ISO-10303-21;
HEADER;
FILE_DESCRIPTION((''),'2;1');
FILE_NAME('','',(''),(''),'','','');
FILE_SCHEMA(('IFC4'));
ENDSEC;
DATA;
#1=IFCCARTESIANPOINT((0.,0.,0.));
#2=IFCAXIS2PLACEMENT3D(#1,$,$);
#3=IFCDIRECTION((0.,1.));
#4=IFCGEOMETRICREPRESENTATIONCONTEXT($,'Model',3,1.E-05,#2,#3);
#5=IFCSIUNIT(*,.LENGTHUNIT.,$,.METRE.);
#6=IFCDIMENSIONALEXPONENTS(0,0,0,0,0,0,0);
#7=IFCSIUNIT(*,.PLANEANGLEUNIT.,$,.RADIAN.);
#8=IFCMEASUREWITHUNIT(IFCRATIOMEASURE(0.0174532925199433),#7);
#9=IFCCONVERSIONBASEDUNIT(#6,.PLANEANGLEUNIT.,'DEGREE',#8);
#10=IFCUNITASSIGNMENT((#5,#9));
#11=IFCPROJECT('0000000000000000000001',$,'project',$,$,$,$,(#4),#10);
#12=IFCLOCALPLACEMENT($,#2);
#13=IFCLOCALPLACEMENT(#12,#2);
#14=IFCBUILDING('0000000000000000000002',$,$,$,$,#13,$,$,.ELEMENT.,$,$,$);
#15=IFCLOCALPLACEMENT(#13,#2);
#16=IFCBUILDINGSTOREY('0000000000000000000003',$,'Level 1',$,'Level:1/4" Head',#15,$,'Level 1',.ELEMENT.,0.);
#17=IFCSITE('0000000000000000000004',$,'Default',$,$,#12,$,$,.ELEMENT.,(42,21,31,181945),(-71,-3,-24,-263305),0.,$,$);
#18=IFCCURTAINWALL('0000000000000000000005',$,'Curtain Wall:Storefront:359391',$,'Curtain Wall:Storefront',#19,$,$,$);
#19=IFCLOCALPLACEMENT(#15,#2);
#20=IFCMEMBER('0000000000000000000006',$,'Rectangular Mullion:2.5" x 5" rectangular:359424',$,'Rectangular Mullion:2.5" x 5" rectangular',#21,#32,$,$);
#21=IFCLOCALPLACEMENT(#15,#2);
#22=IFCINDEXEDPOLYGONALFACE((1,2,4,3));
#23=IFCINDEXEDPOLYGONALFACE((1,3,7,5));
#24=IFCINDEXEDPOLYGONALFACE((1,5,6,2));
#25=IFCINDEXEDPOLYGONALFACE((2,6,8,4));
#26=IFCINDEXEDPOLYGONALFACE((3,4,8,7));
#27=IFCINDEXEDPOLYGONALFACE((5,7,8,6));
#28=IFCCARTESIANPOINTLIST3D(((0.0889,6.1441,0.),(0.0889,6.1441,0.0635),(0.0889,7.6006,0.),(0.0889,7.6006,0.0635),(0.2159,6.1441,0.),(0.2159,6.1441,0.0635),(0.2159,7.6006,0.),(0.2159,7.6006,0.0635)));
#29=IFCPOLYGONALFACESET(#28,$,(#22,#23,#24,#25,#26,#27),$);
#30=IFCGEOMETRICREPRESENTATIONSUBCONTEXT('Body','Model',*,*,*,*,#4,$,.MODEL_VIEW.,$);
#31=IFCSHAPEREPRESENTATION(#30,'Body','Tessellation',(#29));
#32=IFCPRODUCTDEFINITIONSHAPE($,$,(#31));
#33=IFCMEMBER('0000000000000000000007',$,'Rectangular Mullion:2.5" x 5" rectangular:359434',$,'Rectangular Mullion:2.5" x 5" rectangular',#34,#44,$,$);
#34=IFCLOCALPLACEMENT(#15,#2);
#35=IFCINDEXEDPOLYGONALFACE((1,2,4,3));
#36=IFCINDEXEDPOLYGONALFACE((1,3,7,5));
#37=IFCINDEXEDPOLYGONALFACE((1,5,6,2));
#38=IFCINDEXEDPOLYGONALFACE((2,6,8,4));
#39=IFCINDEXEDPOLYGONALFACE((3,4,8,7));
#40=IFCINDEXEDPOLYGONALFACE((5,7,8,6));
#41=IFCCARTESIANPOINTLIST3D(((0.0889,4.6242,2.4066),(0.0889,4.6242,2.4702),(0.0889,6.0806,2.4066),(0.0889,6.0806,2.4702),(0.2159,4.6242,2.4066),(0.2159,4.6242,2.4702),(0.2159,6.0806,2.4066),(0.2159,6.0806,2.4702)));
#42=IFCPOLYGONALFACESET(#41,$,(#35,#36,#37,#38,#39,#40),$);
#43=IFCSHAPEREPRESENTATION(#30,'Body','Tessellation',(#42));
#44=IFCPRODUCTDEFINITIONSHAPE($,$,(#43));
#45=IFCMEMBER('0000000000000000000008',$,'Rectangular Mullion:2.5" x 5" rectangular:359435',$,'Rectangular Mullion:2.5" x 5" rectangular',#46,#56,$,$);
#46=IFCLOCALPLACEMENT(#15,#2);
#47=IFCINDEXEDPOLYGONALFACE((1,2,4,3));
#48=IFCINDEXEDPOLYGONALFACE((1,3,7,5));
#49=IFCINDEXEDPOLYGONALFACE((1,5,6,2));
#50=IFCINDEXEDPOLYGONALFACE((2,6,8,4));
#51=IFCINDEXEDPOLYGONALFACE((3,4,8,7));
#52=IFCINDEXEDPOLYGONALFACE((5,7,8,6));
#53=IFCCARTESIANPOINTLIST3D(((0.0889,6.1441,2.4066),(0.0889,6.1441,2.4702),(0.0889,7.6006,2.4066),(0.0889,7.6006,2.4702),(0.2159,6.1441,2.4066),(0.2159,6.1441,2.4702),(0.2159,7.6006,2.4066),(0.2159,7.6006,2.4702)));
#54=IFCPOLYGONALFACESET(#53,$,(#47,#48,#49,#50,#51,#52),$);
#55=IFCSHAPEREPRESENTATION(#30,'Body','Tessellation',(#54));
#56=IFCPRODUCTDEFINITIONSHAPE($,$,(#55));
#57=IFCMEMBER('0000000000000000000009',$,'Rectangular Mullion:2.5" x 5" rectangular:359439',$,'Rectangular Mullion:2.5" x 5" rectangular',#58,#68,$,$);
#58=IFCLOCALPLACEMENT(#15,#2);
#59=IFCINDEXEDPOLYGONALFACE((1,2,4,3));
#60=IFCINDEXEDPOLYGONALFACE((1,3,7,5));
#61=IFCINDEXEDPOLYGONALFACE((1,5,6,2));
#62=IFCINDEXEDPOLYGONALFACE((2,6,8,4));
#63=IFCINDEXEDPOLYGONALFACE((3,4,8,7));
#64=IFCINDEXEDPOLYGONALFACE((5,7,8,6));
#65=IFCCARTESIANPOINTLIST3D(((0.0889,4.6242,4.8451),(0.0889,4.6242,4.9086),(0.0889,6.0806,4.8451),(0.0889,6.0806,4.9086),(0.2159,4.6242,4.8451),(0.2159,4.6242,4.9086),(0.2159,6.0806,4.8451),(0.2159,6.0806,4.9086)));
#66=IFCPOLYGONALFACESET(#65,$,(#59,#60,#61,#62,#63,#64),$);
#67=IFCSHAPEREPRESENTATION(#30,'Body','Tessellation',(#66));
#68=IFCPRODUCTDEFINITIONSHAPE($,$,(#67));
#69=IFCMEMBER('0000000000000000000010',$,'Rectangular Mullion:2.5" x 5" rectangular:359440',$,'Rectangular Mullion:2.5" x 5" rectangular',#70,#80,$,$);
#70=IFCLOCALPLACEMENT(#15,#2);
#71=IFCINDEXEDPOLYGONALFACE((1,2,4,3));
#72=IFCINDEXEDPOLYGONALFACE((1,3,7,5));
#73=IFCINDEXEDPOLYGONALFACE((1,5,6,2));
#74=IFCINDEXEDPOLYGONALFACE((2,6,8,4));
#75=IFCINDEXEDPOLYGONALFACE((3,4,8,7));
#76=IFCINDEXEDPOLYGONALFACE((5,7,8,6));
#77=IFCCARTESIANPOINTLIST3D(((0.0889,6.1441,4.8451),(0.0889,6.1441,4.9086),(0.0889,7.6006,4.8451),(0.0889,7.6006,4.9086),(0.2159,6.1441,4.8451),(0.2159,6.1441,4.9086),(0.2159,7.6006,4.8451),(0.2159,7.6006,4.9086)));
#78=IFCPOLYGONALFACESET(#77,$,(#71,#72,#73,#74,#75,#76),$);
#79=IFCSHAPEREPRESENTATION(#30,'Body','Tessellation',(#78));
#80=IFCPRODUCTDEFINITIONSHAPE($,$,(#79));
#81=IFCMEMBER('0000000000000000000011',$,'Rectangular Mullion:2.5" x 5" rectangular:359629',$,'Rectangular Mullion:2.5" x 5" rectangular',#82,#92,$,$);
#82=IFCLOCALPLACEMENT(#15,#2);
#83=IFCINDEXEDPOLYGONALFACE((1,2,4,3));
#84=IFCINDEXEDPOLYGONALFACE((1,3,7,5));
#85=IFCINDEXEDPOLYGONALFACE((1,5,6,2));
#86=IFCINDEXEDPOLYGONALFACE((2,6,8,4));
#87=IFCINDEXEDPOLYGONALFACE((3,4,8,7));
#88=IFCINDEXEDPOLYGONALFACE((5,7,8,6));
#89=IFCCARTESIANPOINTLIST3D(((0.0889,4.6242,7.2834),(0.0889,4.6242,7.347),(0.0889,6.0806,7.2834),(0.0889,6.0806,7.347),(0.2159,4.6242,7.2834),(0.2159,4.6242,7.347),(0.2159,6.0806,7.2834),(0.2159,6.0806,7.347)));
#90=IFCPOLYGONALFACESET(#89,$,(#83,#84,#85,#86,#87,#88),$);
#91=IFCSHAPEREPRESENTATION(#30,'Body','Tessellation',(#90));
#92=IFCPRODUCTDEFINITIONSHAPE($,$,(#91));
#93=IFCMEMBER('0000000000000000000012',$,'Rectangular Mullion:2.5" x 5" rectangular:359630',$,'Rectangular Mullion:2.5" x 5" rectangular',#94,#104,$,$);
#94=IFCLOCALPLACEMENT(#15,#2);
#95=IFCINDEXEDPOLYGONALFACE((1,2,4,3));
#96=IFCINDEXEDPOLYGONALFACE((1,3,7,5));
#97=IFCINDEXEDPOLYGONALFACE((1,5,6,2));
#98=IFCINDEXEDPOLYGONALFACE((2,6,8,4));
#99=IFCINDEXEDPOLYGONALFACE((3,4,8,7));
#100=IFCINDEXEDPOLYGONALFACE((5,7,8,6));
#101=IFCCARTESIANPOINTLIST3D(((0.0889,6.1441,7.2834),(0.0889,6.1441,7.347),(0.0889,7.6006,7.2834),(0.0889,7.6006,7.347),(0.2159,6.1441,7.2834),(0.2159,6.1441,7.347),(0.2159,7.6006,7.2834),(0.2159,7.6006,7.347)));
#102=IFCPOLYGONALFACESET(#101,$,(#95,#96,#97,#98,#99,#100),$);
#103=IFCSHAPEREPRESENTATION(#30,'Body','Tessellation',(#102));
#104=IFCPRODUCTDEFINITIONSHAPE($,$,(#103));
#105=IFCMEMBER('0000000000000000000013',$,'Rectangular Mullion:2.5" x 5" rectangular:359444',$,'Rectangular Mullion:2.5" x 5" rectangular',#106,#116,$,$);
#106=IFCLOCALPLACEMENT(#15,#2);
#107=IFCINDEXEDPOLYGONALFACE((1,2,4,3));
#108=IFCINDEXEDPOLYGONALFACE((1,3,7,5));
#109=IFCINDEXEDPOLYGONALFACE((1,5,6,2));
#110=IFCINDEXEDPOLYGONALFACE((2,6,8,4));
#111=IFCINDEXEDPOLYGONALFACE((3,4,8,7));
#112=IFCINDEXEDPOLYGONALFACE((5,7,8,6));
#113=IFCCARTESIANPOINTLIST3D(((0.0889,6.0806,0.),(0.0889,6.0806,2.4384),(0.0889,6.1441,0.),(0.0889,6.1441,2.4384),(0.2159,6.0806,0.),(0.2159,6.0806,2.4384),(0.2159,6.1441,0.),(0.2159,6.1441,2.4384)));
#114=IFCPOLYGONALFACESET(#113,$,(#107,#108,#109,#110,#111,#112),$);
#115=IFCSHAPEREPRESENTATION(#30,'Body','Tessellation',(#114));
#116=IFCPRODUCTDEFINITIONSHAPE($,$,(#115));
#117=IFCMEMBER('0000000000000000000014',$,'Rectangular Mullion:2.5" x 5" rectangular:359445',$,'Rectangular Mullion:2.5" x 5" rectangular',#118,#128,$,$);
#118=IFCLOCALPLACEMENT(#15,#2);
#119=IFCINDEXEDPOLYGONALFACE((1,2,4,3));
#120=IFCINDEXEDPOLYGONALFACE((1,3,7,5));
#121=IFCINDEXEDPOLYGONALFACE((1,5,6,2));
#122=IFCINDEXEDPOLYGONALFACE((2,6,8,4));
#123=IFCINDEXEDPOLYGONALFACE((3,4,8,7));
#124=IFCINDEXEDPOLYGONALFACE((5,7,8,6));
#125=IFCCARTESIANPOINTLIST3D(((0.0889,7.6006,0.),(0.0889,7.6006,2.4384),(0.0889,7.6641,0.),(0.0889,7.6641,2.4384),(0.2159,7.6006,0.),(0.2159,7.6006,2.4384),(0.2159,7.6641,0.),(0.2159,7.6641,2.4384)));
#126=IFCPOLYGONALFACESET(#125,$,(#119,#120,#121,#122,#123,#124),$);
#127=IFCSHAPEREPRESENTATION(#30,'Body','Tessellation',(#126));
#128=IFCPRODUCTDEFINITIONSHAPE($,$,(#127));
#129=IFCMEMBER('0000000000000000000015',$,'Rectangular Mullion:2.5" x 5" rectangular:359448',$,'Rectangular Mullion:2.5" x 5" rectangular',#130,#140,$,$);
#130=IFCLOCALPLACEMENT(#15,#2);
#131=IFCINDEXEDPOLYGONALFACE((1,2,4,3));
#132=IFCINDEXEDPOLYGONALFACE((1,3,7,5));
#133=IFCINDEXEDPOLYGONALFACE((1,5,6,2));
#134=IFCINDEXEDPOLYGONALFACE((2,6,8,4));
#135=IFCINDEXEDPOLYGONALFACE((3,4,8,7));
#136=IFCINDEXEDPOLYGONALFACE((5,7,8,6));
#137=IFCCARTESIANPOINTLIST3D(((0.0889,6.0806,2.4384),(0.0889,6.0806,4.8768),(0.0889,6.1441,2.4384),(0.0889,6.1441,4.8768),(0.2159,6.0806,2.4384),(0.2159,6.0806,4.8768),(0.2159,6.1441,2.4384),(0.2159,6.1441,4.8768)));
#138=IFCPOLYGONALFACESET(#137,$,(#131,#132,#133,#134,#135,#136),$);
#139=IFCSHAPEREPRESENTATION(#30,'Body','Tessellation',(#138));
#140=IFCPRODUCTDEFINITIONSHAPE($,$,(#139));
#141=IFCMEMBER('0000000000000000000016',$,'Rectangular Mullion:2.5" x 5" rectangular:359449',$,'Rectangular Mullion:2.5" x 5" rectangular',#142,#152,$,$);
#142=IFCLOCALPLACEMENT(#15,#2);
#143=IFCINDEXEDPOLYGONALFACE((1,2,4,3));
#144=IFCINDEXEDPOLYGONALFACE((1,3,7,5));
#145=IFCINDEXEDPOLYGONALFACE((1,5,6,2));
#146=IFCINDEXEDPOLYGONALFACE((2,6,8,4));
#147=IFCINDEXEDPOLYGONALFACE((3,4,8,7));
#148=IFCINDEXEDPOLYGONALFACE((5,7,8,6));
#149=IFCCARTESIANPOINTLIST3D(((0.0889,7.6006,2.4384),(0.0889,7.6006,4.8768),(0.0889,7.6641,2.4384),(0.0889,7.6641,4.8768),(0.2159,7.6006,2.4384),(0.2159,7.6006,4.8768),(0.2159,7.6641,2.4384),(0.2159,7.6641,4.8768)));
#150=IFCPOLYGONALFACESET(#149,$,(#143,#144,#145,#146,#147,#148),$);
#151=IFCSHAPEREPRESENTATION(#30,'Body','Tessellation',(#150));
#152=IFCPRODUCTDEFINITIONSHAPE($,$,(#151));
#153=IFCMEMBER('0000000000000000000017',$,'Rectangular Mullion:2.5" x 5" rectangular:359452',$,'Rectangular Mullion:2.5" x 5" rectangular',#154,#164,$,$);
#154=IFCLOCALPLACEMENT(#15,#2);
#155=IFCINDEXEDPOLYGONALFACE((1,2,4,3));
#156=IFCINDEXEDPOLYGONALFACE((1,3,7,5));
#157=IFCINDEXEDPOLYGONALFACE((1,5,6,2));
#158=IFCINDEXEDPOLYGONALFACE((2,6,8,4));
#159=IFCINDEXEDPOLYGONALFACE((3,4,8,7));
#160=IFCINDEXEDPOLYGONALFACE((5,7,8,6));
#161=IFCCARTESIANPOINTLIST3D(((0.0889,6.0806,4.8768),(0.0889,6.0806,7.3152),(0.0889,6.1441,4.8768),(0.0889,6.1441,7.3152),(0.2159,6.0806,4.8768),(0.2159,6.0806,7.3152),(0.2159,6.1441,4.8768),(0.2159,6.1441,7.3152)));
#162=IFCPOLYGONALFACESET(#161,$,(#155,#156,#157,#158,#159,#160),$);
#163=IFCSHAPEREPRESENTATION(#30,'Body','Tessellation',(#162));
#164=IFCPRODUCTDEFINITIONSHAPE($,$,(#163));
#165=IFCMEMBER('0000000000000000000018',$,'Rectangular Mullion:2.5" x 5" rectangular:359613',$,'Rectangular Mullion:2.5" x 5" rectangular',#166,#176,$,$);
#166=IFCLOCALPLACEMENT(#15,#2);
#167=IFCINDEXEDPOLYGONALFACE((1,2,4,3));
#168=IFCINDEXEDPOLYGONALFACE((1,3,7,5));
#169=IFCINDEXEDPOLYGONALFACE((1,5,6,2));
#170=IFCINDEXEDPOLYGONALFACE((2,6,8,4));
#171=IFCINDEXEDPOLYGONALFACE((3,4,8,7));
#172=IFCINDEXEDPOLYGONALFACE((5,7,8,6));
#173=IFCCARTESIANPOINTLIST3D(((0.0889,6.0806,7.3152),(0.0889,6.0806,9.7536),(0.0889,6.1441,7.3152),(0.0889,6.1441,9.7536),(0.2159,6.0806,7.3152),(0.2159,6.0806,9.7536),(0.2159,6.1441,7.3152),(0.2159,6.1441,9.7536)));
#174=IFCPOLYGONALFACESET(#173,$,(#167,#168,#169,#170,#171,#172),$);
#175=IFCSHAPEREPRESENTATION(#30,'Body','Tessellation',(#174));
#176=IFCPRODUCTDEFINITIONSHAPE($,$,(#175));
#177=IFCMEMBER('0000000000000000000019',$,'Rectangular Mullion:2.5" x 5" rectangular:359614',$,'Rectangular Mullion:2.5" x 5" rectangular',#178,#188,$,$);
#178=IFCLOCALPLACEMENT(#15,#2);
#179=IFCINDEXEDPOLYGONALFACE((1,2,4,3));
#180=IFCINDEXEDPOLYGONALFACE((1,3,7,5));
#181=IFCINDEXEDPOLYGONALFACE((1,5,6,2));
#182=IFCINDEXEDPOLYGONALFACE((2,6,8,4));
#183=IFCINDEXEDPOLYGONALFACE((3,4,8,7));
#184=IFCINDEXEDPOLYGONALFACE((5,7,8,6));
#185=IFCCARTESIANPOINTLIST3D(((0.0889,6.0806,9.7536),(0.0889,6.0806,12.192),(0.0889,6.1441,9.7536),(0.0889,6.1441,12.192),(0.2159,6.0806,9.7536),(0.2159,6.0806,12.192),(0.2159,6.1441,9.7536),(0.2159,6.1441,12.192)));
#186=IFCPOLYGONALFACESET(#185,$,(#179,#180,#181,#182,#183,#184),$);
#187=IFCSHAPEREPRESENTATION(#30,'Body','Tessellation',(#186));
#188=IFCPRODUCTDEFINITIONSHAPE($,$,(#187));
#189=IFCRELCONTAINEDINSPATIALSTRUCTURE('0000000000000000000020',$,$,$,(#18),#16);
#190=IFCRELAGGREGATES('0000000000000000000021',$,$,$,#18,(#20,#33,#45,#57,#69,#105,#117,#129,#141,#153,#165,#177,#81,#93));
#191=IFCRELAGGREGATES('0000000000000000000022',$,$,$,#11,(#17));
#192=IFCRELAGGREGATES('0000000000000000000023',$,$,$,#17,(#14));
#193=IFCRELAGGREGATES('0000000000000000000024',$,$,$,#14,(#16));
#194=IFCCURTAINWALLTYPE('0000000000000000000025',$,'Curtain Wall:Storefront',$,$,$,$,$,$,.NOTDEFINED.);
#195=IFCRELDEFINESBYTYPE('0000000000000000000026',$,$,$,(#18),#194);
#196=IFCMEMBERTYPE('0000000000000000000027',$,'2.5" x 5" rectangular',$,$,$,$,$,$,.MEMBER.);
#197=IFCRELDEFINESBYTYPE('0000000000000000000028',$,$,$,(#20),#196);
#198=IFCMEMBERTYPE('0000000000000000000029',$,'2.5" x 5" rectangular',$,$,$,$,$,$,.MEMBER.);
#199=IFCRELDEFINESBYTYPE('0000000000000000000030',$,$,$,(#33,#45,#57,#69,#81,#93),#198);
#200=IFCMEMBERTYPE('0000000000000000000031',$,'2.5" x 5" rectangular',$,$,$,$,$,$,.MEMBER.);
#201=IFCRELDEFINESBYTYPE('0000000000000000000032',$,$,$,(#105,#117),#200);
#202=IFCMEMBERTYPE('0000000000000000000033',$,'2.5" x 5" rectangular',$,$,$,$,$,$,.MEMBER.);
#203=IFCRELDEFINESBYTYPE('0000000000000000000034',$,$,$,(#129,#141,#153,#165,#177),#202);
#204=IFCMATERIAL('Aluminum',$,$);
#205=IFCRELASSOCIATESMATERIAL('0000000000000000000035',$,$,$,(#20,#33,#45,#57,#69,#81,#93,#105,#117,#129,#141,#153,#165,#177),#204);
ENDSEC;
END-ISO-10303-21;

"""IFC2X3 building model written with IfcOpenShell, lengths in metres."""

from ifc_helpers import new_model, entity, si_unit, converted_unit, direction, frame, origin, origin_2d_with_axis, place, context, subcontext, project, spatial, rectangle, extrude, source, transform, mapped, material, type_object, type_shapes, element, aggregate, save


model = new_model("IFC2X3")

# Units and contexts
model_context = context("Model", 3, precision=1e-05, world=origin(), true_north=direction((0.0, 1.0)))
body_context = subcontext(model_context, "Body", "Model", "MODEL_VIEW")
ifc_project = project(units=[si_unit("LENGTHUNIT", "METRE"), converted_unit("PLANEANGLEUNIT", "DEGREE", entity("IfcRatioMeasure", 0.0174532925199433), si_unit("PLANEANGLEUNIT", "RADIAN"), dimensions=[0, 0, 0, 0, 0, 0, 0])], contexts=[model_context])

# Site, building, storey
site_placement = place(None, origin())
site = spatial("IfcSite", under=ifc_project, at=site_placement, Name="Default", CompositionType="ELEMENT", RefLatitude=(42, 21, 31, 181945), RefLongitude=(-71, -3, -24, -263305), RefElevation=0.0)
building_placement = place(site_placement, origin())
building = spatial("IfcBuilding", under=site, at=building_placement, CompositionType="ELEMENT")
storey_placement = place(building_placement, origin())
storey = spatial("IfcBuildingStorey", under=building, at=storey_placement, Name="Level 1", ObjectType="Level:1/4\" Head", LongName="Level 1", CompositionType="ELEMENT", Elevation=0.0)

# Curtain wall, members
curtain_wall_type = type_object("IfcCurtainWallType", Name="Curtain Wall:Storefront", PredefinedType="NOTDEFINED")
curtain_wall_1_placement = place(storey_placement, origin())
curtain_wall_1 = element("IfcCurtainWall", 1, at=curtain_wall_1_placement, inside=storey, type_object=curtain_wall_type, Name="Curtain Wall:Storefront:359391", ObjectType="Curtain Wall:Storefront")
ifc_material_1 = material(Name="Aluminum")
member_type_1 = type_object("IfcMemberType", Name="2.5\" x 5\" rectangular", PredefinedType="MEMBER")
shared_shape_1 = source(origin(), body_context, "Body", "SweptSolid", [
    extrude(rectangle(XDim=0.127, YDim=0.0635, at=origin_2d_with_axis()), frame((-0.0318, 0.0, -1.4565), z_axis=(0.0, 0.0, 1.0), x_axis=(0.0, -1.0, 0.0)), (0.0, 0.0, 1.0), 1.4565),
])
type_shapes(member_type_1, [shared_shape_1])
member_1_placement = place(storey_placement, frame((0.1524, 6.1441, 0.0), z_axis=(0.0, -1.0, 0.0), x_axis=(0.0, 0.0, -1.0)))
member_1 = element("IfcMember", 2, at=member_1_placement, type_object=member_type_1, material=ifc_material_1, Name="Rectangular Mullion:2.5\" x 5\" rectangular:359424", ObjectType="Rectangular Mullion:2.5\" x 5\" rectangular", context=body_context, shape_type="MappedRepresentation", body=[
    mapped(shared_shape_1, transform((0.0, 0.0, 0.0), scale=1.0)),
])
member_type_2 = type_object("IfcMemberType", Name="2.5\" x 5\" rectangular", PredefinedType="MEMBER")
shared_shape_2 = source(origin(), body_context, "Body", "SweptSolid", [
    extrude(rectangle(XDim=0.127, YDim=0.0635, at=origin_2d_with_axis()), frame((0.0, 0.0, -1.4565), z_axis=(0.0, 0.0, 1.0), x_axis=(0.0, -1.0, 0.0)), (0.0, 0.0, 1.0), 1.4565),
])
type_shapes(member_type_2, [shared_shape_2])
member_2_placement = place(storey_placement, frame((0.1524, 6.0806, 2.4384), z_axis=(0.0, 1.0, 0.0), x_axis=(0.0, 0.0, 1.0)))
member_2 = element("IfcMember", 3, at=member_2_placement, type_object=member_type_2, material=ifc_material_1, Name="Rectangular Mullion:2.5\" x 5\" rectangular:359434", ObjectType="Rectangular Mullion:2.5\" x 5\" rectangular", context=body_context, shape_type="MappedRepresentation", body=[
    mapped(shared_shape_2, transform((0.0, 0.0, 0.0), scale=1.0)),
])
member_3_placement = place(storey_placement, frame((0.1524, 7.6006, 2.4384), z_axis=(0.0, 1.0, 0.0), x_axis=(0.0, 0.0, 1.0)))
member_3 = element("IfcMember", 4, at=member_3_placement, type_object=member_type_2, material=ifc_material_1, Name="Rectangular Mullion:2.5\" x 5\" rectangular:359435", ObjectType="Rectangular Mullion:2.5\" x 5\" rectangular", context=body_context, shape_type="MappedRepresentation", body=[
    mapped(shared_shape_2, transform((0.0, 0.0, 0.0), scale=1.0)),
])
member_4_placement = place(storey_placement, frame((0.1524, 6.0806, 4.8768), z_axis=(0.0, 1.0, 0.0), x_axis=(0.0, 0.0, 1.0)))
member_4 = element("IfcMember", 5, at=member_4_placement, type_object=member_type_2, material=ifc_material_1, Name="Rectangular Mullion:2.5\" x 5\" rectangular:359439", ObjectType="Rectangular Mullion:2.5\" x 5\" rectangular", context=body_context, shape_type="MappedRepresentation", body=[
    mapped(shared_shape_2, transform((0.0, 0.0, 0.0), scale=1.0)),
])
member_5_placement = place(storey_placement, frame((0.1524, 7.6006, 4.8768), z_axis=(0.0, 1.0, 0.0), x_axis=(0.0, 0.0, 1.0)))
member_5 = element("IfcMember", 6, at=member_5_placement, type_object=member_type_2, material=ifc_material_1, Name="Rectangular Mullion:2.5\" x 5\" rectangular:359440", ObjectType="Rectangular Mullion:2.5\" x 5\" rectangular", context=body_context, shape_type="MappedRepresentation", body=[
    mapped(shared_shape_2, transform((0.0, 0.0, 0.0), scale=1.0)),
])
member_6_placement = place(storey_placement, frame((0.1524, 6.0806, 7.3152), z_axis=(0.0, 1.0, 0.0), x_axis=(0.0, 0.0, 1.0)))
member_6 = element("IfcMember", 7, at=member_6_placement, type_object=member_type_2, material=ifc_material_1, Name="Rectangular Mullion:2.5\" x 5\" rectangular:359629", ObjectType="Rectangular Mullion:2.5\" x 5\" rectangular", context=body_context, shape_type="MappedRepresentation", body=[
    mapped(shared_shape_2, transform((0.0, 0.0, 0.0), scale=1.0)),
])
member_7_placement = place(storey_placement, frame((0.1524, 7.6006, 7.3152), z_axis=(0.0, 1.0, 0.0), x_axis=(0.0, 0.0, 1.0)))
member_7 = element("IfcMember", 8, at=member_7_placement, type_object=member_type_2, material=ifc_material_1, Name="Rectangular Mullion:2.5\" x 5\" rectangular:359630", ObjectType="Rectangular Mullion:2.5\" x 5\" rectangular", context=body_context, shape_type="MappedRepresentation", body=[
    mapped(shared_shape_2, transform((0.0, 0.0, 0.0), scale=1.0)),
])
member_type_3 = type_object("IfcMemberType", Name="2.5\" x 5\" rectangular", PredefinedType="MEMBER")
shared_shape_3 = source(origin(), body_context, "Body", "SweptSolid", [
    extrude(rectangle(XDim=0.127, YDim=0.0635, at=origin_2d_with_axis()), frame((0.0, 0.0, -2.4384), z_axis=(0.0, 0.0, 1.0), x_axis=(0.0, -1.0, 0.0)), (0.0, 0.0, 1.0), 2.4384),
])
type_shapes(member_type_3, [shared_shape_3])
member_8_placement = place(storey_placement, frame((0.1524, 6.1124, 0.0), z_axis=(0.0, 0.0, -1.0), x_axis=(0.0, 1.0, 0.0)))
member_8 = element("IfcMember", 9, at=member_8_placement, type_object=member_type_3, material=ifc_material_1, Name="Rectangular Mullion:2.5\" x 5\" rectangular:359444", ObjectType="Rectangular Mullion:2.5\" x 5\" rectangular", context=body_context, shape_type="MappedRepresentation", body=[
    mapped(shared_shape_3, transform((0.0, 0.0, 0.0), scale=1.0)),
])
member_9_placement = place(storey_placement, frame((0.1524, 7.6324, 0.0), z_axis=(0.0, 0.0, -1.0), x_axis=(0.0, 1.0, 0.0)))
member_9 = element("IfcMember", 10, at=member_9_placement, type_object=member_type_3, material=ifc_material_1, Name="Rectangular Mullion:2.5\" x 5\" rectangular:359445", ObjectType="Rectangular Mullion:2.5\" x 5\" rectangular", context=body_context, shape_type="MappedRepresentation", body=[
    mapped(shared_shape_3, transform((0.0, 0.0, 0.0), scale=1.0)),
])
member_type_4 = type_object("IfcMemberType", Name="2.5\" x 5\" rectangular", PredefinedType="MEMBER")
shared_shape_4 = source(origin(), body_context, "Body", "SweptSolid", [
    extrude(rectangle(XDim=0.127, YDim=0.0635, at=origin_2d_with_axis()), frame((0.0, 0.0, -2.4384), z_axis=(0.0, 0.0, 1.0), x_axis=(0.0, -1.0, 0.0)), (0.0, 0.0, 1.0), 2.4384),
])
type_shapes(member_type_4, [shared_shape_4])
member_10_placement = place(storey_placement, frame((0.1524, 6.1124, 2.4384), z_axis=(0.0, 0.0, -1.0), x_axis=(0.0, 1.0, 0.0)))
member_10 = element("IfcMember", 11, at=member_10_placement, type_object=member_type_4, material=ifc_material_1, Name="Rectangular Mullion:2.5\" x 5\" rectangular:359448", ObjectType="Rectangular Mullion:2.5\" x 5\" rectangular", context=body_context, shape_type="MappedRepresentation", body=[
    mapped(shared_shape_4, transform((0.0, 0.0, 0.0), scale=1.0)),
])
member_11_placement = place(storey_placement, frame((0.1524, 7.6324, 2.4384), z_axis=(0.0, 0.0, -1.0), x_axis=(0.0, 1.0, 0.0)))
member_11 = element("IfcMember", 12, at=member_11_placement, type_object=member_type_4, material=ifc_material_1, Name="Rectangular Mullion:2.5\" x 5\" rectangular:359449", ObjectType="Rectangular Mullion:2.5\" x 5\" rectangular", context=body_context, shape_type="MappedRepresentation", body=[
    mapped(shared_shape_4, transform((0.0, 0.0, 0.0), scale=1.0)),
])
member_12_placement = place(storey_placement, frame((0.1524, 6.1124, 4.8768), z_axis=(0.0, 0.0, -1.0), x_axis=(0.0, 1.0, 0.0)))
member_12 = element("IfcMember", 13, at=member_12_placement, type_object=member_type_4, material=ifc_material_1, Name="Rectangular Mullion:2.5\" x 5\" rectangular:359452", ObjectType="Rectangular Mullion:2.5\" x 5\" rectangular", context=body_context, shape_type="MappedRepresentation", body=[
    mapped(shared_shape_4, transform((0.0, 0.0, 0.0), scale=1.0)),
])
member_13_placement = place(storey_placement, frame((0.1524, 6.1124, 7.3152), z_axis=(0.0, 0.0, -1.0), x_axis=(0.0, 1.0, 0.0)))
member_13 = element("IfcMember", 14, at=member_13_placement, type_object=member_type_4, material=ifc_material_1, Name="Rectangular Mullion:2.5\" x 5\" rectangular:359613", ObjectType="Rectangular Mullion:2.5\" x 5\" rectangular", context=body_context, shape_type="MappedRepresentation", body=[
    mapped(shared_shape_4, transform((0.0, 0.0, 0.0), scale=1.0)),
])
member_14_placement = place(storey_placement, frame((0.1524, 6.1124, 9.7536), z_axis=(0.0, 0.0, -1.0), x_axis=(0.0, 1.0, 0.0)))
member_14 = element("IfcMember", 15, at=member_14_placement, type_object=member_type_4, material=ifc_material_1, Name="Rectangular Mullion:2.5\" x 5\" rectangular:359614", ObjectType="Rectangular Mullion:2.5\" x 5\" rectangular", context=body_context, shape_type="MappedRepresentation", body=[
    mapped(shared_shape_4, transform((0.0, 0.0, 0.0), scale=1.0)),
])

aggregate(curtain_wall_1, [member_1, member_2, member_3, member_4, member_5, member_8, member_9, member_10, member_11, member_12, member_13, member_14, member_6, member_7])

save(model, "model.ifc")
